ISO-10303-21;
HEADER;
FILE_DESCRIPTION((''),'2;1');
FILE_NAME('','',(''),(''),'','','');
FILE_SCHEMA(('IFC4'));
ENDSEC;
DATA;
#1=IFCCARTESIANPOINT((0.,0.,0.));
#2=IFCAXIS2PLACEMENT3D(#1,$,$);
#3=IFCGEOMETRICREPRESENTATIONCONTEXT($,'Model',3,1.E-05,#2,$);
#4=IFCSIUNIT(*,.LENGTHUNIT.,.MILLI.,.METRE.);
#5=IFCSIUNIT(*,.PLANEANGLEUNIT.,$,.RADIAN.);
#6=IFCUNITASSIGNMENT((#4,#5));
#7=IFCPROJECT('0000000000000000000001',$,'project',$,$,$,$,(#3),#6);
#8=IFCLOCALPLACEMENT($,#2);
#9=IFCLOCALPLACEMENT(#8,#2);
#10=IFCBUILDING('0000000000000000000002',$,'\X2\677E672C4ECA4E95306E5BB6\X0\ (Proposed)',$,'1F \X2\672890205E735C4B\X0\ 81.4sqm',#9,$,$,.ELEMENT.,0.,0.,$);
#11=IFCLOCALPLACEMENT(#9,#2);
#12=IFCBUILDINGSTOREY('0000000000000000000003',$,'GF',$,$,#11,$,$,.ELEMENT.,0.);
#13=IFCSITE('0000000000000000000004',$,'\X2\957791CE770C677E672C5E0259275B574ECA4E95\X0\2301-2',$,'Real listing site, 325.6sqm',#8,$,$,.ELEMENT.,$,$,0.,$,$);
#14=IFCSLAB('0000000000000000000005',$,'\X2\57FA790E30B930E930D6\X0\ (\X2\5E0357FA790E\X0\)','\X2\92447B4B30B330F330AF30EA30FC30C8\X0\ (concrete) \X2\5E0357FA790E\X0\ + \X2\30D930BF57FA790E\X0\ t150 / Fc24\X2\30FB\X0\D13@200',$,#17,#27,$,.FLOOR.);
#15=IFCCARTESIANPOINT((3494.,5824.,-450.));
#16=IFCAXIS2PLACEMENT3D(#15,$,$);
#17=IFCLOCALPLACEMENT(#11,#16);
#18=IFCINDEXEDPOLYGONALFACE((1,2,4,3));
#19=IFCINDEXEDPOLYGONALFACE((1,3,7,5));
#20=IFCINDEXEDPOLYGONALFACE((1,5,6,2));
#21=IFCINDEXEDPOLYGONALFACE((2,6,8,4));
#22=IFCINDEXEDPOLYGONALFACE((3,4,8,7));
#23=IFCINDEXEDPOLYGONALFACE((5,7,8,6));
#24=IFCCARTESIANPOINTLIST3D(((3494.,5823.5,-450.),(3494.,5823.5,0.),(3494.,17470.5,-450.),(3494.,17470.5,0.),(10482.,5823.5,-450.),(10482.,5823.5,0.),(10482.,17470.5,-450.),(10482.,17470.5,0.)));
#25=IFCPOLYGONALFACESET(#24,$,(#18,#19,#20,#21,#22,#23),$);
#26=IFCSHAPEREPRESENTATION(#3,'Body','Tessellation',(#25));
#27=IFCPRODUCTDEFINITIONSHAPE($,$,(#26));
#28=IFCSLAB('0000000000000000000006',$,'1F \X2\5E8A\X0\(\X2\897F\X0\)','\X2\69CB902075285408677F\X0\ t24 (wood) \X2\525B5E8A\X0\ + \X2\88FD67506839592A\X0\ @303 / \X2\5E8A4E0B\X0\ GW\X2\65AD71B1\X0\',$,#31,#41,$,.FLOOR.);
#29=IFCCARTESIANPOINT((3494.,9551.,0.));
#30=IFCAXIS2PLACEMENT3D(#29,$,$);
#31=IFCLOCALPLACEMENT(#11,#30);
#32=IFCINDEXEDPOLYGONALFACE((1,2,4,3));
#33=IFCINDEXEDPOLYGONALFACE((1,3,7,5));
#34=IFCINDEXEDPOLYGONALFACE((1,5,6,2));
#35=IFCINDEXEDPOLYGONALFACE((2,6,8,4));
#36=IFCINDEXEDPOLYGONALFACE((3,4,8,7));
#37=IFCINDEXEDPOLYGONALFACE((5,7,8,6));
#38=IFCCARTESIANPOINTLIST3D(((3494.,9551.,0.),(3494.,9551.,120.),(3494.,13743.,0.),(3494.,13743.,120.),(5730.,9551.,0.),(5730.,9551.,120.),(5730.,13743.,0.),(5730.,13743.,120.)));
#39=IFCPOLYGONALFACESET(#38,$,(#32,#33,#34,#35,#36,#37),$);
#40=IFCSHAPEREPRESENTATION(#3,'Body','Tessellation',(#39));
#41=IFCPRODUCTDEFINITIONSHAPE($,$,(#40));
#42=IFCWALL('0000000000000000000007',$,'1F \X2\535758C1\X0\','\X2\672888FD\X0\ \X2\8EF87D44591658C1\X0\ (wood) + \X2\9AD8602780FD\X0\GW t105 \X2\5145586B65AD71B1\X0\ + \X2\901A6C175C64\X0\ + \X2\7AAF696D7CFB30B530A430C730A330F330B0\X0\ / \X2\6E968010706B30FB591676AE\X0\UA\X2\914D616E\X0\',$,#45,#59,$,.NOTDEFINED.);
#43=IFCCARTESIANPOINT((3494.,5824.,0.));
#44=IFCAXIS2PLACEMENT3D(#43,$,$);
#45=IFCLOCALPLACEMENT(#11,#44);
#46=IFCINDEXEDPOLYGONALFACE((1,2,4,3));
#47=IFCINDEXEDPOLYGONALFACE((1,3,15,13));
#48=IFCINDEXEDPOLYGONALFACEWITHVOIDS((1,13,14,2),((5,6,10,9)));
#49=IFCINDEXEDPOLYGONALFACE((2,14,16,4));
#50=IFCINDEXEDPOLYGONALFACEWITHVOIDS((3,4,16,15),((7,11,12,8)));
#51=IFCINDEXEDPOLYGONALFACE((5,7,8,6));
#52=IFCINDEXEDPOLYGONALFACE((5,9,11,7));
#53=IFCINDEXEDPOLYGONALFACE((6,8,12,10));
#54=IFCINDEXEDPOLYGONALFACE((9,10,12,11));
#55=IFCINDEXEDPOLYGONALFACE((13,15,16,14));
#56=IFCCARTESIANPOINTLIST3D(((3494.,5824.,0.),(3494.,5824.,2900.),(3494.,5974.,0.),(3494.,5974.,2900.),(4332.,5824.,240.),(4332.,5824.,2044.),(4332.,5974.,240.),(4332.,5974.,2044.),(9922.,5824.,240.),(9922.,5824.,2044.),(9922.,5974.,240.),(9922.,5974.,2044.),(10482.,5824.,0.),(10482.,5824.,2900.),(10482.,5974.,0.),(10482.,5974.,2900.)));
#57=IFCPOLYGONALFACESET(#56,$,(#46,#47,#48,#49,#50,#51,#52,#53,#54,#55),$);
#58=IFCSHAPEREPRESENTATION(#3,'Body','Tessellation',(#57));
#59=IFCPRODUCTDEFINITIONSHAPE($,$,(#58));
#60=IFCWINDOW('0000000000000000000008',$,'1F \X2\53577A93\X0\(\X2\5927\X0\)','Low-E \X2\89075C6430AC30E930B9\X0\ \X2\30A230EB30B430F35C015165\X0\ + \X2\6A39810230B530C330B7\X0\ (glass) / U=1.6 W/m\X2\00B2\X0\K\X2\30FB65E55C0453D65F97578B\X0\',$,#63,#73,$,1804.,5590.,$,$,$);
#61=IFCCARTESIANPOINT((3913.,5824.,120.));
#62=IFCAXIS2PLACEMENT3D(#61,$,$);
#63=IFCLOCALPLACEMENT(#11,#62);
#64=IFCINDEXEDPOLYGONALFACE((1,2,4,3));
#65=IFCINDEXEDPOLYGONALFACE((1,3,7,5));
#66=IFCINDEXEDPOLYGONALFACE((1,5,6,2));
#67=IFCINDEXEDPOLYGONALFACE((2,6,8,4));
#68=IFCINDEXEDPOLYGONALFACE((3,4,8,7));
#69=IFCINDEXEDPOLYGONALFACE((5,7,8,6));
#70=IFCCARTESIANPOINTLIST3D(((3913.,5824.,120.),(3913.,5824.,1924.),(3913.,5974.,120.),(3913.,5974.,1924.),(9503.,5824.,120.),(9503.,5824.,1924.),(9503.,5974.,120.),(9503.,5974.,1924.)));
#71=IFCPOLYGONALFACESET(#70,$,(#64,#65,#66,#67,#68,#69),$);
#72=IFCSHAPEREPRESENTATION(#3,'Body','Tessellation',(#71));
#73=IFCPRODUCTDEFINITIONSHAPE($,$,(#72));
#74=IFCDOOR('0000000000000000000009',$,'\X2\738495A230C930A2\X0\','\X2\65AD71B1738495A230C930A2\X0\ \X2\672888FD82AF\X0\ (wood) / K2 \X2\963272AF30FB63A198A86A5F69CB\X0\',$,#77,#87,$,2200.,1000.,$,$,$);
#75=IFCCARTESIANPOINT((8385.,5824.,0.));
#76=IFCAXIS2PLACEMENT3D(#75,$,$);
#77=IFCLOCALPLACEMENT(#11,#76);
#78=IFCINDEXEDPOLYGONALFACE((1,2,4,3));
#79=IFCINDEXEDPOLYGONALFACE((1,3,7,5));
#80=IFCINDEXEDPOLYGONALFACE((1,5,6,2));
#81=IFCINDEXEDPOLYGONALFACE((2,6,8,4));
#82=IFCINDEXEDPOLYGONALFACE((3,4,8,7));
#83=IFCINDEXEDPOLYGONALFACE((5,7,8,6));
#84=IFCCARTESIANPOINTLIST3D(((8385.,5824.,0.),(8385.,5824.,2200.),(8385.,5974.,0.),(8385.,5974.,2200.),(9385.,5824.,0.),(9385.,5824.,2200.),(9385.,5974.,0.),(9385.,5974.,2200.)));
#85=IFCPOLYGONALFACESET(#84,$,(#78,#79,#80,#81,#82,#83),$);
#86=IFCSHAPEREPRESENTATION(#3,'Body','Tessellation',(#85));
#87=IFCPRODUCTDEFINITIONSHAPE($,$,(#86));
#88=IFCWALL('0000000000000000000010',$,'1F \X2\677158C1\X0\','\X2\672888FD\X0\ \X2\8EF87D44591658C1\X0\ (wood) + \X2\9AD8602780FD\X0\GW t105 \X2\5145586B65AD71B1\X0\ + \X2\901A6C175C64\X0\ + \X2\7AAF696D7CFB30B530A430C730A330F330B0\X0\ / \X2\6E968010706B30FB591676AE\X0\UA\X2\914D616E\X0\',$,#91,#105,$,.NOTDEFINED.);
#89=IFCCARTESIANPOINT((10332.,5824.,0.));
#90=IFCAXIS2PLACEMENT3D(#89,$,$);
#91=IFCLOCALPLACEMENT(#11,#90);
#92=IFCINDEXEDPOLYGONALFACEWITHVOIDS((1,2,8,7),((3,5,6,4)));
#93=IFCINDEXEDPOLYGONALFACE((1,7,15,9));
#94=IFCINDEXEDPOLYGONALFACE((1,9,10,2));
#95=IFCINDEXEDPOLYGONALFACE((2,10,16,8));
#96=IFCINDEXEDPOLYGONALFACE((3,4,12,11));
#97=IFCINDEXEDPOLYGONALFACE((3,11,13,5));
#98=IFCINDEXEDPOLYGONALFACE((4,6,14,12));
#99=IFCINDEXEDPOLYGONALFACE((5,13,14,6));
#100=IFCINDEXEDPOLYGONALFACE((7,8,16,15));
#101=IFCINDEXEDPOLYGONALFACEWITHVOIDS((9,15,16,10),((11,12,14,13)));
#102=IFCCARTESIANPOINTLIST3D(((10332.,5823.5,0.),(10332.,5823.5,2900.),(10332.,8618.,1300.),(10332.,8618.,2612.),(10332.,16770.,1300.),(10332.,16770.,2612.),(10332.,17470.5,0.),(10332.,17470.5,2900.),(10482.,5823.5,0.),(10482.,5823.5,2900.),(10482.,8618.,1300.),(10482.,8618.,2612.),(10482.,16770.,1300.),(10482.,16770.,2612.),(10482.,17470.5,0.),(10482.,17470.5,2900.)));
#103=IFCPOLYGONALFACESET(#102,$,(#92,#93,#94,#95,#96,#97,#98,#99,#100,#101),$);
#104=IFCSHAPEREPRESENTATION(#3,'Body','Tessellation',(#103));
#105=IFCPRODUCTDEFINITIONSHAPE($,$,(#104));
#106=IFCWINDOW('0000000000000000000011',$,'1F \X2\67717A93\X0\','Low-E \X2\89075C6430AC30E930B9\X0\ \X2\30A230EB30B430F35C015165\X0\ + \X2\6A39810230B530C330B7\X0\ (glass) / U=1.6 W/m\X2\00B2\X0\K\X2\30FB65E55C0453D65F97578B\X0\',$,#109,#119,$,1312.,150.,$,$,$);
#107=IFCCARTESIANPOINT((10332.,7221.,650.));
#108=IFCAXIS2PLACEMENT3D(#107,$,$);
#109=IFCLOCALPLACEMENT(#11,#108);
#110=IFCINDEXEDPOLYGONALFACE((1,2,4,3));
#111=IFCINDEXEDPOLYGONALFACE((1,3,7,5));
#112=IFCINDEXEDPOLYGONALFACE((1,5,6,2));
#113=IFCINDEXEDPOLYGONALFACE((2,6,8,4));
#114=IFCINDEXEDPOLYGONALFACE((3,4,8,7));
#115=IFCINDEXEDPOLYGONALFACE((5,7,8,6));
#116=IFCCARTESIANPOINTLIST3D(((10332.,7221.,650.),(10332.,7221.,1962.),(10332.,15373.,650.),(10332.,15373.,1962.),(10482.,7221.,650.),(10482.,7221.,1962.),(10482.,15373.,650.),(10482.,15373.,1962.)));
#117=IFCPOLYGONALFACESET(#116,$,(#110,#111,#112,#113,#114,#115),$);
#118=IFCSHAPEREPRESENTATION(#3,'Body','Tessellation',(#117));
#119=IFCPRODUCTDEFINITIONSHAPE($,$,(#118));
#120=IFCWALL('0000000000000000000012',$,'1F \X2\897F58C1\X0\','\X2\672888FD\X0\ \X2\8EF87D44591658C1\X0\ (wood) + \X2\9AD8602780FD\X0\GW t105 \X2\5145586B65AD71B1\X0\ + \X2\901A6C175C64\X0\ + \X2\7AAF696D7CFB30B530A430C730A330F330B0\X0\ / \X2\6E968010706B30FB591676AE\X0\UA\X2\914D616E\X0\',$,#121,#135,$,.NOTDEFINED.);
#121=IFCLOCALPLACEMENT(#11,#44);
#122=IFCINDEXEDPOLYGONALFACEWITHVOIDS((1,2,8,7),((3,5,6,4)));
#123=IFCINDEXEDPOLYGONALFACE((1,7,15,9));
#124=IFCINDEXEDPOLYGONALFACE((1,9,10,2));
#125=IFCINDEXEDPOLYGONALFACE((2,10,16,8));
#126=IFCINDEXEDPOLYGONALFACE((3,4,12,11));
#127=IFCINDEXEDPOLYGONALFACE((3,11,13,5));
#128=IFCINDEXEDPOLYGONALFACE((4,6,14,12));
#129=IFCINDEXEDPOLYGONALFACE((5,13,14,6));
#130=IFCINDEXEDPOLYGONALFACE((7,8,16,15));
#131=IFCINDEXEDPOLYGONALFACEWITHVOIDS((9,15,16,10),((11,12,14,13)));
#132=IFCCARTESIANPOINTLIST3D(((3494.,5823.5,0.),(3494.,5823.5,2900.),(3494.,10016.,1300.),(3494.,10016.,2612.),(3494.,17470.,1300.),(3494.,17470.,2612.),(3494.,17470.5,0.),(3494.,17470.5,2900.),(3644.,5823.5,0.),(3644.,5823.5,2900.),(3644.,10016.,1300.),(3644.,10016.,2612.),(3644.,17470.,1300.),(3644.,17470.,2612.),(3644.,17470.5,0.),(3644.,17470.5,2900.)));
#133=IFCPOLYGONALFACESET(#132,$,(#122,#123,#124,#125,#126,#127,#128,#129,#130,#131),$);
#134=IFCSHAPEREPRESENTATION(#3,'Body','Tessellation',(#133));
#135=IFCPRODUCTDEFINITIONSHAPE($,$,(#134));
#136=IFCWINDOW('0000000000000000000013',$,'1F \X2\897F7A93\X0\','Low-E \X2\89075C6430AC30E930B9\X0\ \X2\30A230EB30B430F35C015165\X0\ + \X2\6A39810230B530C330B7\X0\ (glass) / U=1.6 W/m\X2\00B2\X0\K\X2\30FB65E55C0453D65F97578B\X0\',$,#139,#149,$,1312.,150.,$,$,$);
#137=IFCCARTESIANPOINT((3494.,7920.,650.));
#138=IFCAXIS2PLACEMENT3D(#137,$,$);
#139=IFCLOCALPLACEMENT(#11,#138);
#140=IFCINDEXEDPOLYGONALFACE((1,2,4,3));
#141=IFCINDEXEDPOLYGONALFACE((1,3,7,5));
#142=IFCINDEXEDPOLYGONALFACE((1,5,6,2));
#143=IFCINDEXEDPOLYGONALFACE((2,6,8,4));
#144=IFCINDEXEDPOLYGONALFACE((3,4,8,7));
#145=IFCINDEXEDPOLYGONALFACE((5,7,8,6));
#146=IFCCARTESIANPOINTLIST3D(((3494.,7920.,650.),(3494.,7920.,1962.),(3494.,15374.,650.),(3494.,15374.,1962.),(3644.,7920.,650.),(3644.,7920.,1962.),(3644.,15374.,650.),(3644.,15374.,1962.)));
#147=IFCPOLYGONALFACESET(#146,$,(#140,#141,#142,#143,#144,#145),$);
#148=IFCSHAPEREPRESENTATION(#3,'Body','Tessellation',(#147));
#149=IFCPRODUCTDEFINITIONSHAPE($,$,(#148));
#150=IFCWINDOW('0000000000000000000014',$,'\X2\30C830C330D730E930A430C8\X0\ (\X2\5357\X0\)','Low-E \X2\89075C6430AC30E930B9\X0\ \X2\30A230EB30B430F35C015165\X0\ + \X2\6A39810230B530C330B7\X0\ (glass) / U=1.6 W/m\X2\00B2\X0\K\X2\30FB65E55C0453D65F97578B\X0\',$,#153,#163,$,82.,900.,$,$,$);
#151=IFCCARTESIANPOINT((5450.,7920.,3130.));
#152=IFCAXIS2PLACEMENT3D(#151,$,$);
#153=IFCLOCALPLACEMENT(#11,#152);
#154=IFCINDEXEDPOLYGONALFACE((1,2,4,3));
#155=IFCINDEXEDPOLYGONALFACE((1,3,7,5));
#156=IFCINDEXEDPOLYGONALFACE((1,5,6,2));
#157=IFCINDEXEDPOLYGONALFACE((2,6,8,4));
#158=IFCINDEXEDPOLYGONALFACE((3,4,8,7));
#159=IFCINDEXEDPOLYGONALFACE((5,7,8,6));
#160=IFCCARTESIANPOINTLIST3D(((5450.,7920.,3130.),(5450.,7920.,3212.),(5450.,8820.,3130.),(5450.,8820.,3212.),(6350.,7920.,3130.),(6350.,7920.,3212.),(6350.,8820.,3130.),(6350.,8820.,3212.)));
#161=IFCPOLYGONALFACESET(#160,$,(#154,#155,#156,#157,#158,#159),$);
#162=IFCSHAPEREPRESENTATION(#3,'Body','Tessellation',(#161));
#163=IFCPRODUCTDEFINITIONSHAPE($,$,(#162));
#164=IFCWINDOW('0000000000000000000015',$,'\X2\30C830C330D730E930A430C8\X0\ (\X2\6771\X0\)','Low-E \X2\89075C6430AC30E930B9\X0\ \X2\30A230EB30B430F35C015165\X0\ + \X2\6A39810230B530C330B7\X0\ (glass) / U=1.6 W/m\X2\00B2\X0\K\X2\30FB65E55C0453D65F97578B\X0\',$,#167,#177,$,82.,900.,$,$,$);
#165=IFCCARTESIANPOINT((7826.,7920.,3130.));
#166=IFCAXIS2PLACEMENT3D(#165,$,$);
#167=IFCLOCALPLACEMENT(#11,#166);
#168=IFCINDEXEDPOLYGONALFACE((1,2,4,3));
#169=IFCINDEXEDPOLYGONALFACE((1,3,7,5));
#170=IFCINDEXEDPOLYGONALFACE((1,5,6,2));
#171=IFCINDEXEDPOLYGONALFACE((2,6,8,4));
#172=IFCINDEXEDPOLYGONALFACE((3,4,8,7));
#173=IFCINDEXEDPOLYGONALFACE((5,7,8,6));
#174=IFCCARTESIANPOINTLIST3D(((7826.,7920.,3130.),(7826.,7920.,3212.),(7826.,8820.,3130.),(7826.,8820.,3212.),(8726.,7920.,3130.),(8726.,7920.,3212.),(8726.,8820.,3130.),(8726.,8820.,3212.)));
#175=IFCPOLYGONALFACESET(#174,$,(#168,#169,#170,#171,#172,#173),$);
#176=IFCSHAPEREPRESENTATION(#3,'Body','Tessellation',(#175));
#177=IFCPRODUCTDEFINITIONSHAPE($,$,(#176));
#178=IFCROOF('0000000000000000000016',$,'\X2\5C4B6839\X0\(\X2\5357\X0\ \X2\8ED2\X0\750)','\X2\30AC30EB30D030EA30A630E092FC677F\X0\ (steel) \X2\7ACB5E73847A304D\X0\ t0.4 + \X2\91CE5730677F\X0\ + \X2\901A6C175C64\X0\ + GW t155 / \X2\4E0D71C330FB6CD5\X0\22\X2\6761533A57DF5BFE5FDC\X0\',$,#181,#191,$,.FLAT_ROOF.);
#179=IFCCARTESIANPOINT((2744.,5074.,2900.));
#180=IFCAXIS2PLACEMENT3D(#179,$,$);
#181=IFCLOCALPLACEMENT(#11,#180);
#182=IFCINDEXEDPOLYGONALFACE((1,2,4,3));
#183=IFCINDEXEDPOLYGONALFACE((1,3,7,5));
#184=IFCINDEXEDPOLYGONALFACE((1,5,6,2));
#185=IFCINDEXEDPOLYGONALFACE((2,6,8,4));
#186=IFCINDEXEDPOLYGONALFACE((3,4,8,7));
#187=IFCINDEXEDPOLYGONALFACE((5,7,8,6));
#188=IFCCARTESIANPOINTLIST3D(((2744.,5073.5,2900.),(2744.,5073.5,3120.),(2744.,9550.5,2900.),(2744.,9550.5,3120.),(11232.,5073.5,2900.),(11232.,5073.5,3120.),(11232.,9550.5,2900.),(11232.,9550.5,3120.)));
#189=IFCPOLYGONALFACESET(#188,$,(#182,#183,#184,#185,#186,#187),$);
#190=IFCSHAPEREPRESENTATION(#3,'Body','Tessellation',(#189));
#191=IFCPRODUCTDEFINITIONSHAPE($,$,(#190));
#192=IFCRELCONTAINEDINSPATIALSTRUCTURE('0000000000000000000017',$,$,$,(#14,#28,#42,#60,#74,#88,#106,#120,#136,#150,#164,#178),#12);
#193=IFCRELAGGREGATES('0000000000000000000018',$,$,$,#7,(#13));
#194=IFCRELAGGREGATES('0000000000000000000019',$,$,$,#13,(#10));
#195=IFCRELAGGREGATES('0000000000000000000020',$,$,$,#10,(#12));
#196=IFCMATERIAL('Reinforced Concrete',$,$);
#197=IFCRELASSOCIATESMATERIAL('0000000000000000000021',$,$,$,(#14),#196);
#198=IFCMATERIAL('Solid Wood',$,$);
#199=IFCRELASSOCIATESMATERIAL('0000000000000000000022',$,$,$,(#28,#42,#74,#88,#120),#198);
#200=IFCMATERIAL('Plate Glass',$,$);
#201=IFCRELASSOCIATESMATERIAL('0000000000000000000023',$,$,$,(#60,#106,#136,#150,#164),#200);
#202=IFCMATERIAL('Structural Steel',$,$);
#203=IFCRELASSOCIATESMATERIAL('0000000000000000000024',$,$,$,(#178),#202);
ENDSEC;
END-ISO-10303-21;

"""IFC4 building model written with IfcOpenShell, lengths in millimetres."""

from ifc_helpers import new_model, si_unit, frame, frame_2d, origin, place, context, project, spatial, rectangle, extrude, material, element, fill, save


model = new_model("IFC4")

# Units and contexts
model_context = context("Model", 3, precision=1e-05, world=origin())
ifc_project = project(units=[si_unit("LENGTHUNIT", "METRE", prefix="MILLI"), si_unit("PLANEANGLEUNIT", "RADIAN")], contexts=[model_context])

# Site, building, storey
site_placement = place(None, origin())
site = spatial("IfcSite", under=ifc_project, at=site_placement, Name="長野県松本市大字今井2301-2", ObjectType="Real listing site, 325.6sqm", CompositionType="ELEMENT", RefElevation=0.0)
building_placement = place(site_placement, origin())
building = spatial("IfcBuilding", under=site, at=building_placement, Name="松本今井の家 (Proposed)", ObjectType="1F 木造平屋 81.4sqm", CompositionType="ELEMENT", ElevationOfRefHeight=0.0, ElevationOfTerrain=0.0)
storey_placement = place(building_placement, origin())
storey = spatial("IfcBuildingStorey", under=building, at=storey_placement, Name="GF", CompositionType="ELEMENT", Elevation=0.0)

# Slabs
ifc_material_1 = material(Name="Reinforced Concrete")
slab_1_placement = place(storey_placement, frame((3494.0, 5824.0, -450.0)))
element("IfcSlab", 1, at=slab_1_placement, inside=storey, material=ifc_material_1, Name="基礎スラブ (布基礎)", Description="鉄筋コンクリート (concrete) 布基礎 + ベタ基礎 t150 / Fc24・D13@200", PredefinedType="FLOOR", context=model_context, shape_type="SweptSolid", body=[
    extrude(rectangle(XDim=6988.0, YDim=11647.0, at=frame_2d((3494.0, 5823.0))), frame((3494.0, 5824.0, -450.0)), (0.0, 0.0, 1.0), 450.0),
])
ifc_material_2 = material(Name="Solid Wood")
slab_2_placement = place(storey_placement, frame((3494.0, 9551.0, 0.0)))
element("IfcSlab", 2, at=slab_2_placement, inside=storey, material=ifc_material_2, Name="1F 床(西)", Description="構造用合板 t24 (wood) 剛床 + 製材根太 @303 / 床下 GW断熱", PredefinedType="FLOOR", context=model_context, shape_type="SweptSolid", body=[
    extrude(rectangle(XDim=2236.0, YDim=4192.0, at=frame_2d((1118.0, 2096.0))), frame((3494.0, 9551.0, 0.0)), (0.0, 0.0, 1.0), 120.0),
])

# Wall, openings, window, door
wall_1_placement = place(storey_placement, frame((3494.0, 5824.0, 0.0)))
wall_1 = element("IfcWall", 3, at=wall_1_placement, inside=storey, material=ifc_material_2, Name="1F 南壁", Description="木製 軸組外壁 (wood) + 高性能GW t105 充填断熱 + 通気層 + 窯業系サイディング / 準耐火・外皮UA配慮", PredefinedType="NOTDEFINED", context=model_context, shape_type="SweptSolid", body=[
    extrude(rectangle(XDim=6988.0, YDim=150.0, at=frame_2d((3494.0, 75.0))), frame((3494.0, 5824.0, 0.0)), (0.0, 0.0, 1.0), 2900.0),
])
opening_1_placement = place(storey_placement, frame((3913.0, 5824.0, 120.0)))
opening_1 = element("IfcOpeningElement", 4, at=opening_1_placement, cuts=wall_1, PredefinedType="NOTDEFINED", context=model_context, shape_type="SweptSolid", body=[
    extrude(rectangle(XDim=5590.0, YDim=150.0, at=frame_2d((2795.0, 75.0))), frame((3913.0, 5824.0, 120.0)), (0.0, 0.0, 1.0), 1804.0),
])
opening_2_placement = place(storey_placement, frame((8385.0, 5824.0, 0.0)))
opening_2 = element("IfcOpeningElement", 5, at=opening_2_placement, cuts=wall_1, PredefinedType="NOTDEFINED", context=model_context, shape_type="SweptSolid", body=[
    extrude(rectangle(XDim=1000.0, YDim=150.0, at=frame_2d((500.0, 75.0))), frame((8385.0, 5824.0, 0.0)), (0.0, 0.0, 1.0), 2200.0),
])
ifc_material_3 = material(Name="Plate Glass")
window_1_placement = place(storey_placement, frame((3913.0, 5824.0, 120.0)))
window_1 = element("IfcWindow", 6, at=window_1_placement, inside=storey, material=ifc_material_3, Name="1F 南窓(大)", Description="Low-E 複層ガラス アルゴン封入 + 樹脂サッシ (glass) / U=1.6 W/m²K・日射取得型", OverallHeight=1804.0, OverallWidth=5590.0, context=model_context, shape_type="SweptSolid", body=[
    extrude(rectangle(XDim=5590.0, YDim=150.0, at=frame_2d((2795.0, 75.0))), frame((3913.0, 5824.0, 120.0)), (0.0, 0.0, 1.0), 1804.0),
])
fill(opening_1, window_1)
door_placement = place(storey_placement, frame((8385.0, 5824.0, 0.0)))
door = element("IfcDoor", 7, at=door_placement, inside=storey, material=ifc_material_2, Name="玄関ドア", Description="断熱玄関ドア 木製芯 (wood) / K2 防犯・採風機構", OverallHeight=2200.0, OverallWidth=1000.0, context=model_context, shape_type="SweptSolid", body=[
    extrude(rectangle(XDim=1000.0, YDim=150.0, at=frame_2d((500.0, 75.0))), frame((8385.0, 5824.0, 0.0)), (0.0, 0.0, 1.0), 2200.0),
])
fill(opening_2, door)

# Walls, openings, windows
wall_2_placement = place(storey_placement, frame((10332.0, 5824.0, 0.0)))
wall_2 = element("IfcWall", 8, at=wall_2_placement, inside=storey, material=ifc_material_2, Name="1F 東壁", Description="木製 軸組外壁 (wood) + 高性能GW t105 充填断熱 + 通気層 + 窯業系サイディング / 準耐火・外皮UA配慮", PredefinedType="NOTDEFINED", context=model_context, shape_type="SweptSolid", body=[
    extrude(rectangle(XDim=150.0, YDim=11647.0, at=frame_2d((75.0, 5823.0))), frame((10332.0, 5824.0, 0.0)), (0.0, 0.0, 1.0), 2900.0),
])
opening_3_placement = place(storey_placement, frame((10332.0, 7221.0, 650.0)))
opening_3 = element("IfcOpeningElement", 9, at=opening_3_placement, cuts=wall_2, PredefinedType="NOTDEFINED", context=model_context, shape_type="SweptSolid", body=[
    extrude(rectangle(XDim=150.0, YDim=8152.0, at=frame_2d((75.0, 4076.0))), frame((10332.0, 7221.0, 650.0)), (0.0, 0.0, 1.0), 1312.0),
])
window_2_placement = place(storey_placement, frame((10332.0, 7221.0, 650.0)))
window_2 = element("IfcWindow", 10, at=window_2_placement, inside=storey, material=ifc_material_3, Name="1F 東窓", Description="Low-E 複層ガラス アルゴン封入 + 樹脂サッシ (glass) / U=1.6 W/m²K・日射取得型", OverallHeight=1312.0, OverallWidth=150.0, context=model_context, shape_type="SweptSolid", body=[
    extrude(rectangle(XDim=150.0, YDim=8152.0, at=frame_2d((75.0, 4076.0))), frame((10332.0, 7221.0, 650.0)), (0.0, 0.0, 1.0), 1312.0),
])
fill(opening_3, window_2)
wall_3_placement = place(storey_placement, frame((3494.0, 5824.0, 0.0)))
wall_3 = element("IfcWall", 11, at=wall_3_placement, inside=storey, material=ifc_material_2, Name="1F 西壁", Description="木製 軸組外壁 (wood) + 高性能GW t105 充填断熱 + 通気層 + 窯業系サイディング / 準耐火・外皮UA配慮", PredefinedType="NOTDEFINED", context=model_context, shape_type="SweptSolid", body=[
    extrude(rectangle(XDim=150.0, YDim=11647.0, at=frame_2d((75.0, 5823.0))), frame((3494.0, 5824.0, 0.0)), (0.0, 0.0, 1.0), 2900.0),
])
opening_4_placement = place(storey_placement, frame((3494.0, 7920.0, 650.0)))
opening_4 = element("IfcOpeningElement", 12, at=opening_4_placement, cuts=wall_3, PredefinedType="NOTDEFINED", context=model_context, shape_type="SweptSolid", body=[
    extrude(rectangle(XDim=150.0, YDim=7454.0, at=frame_2d((75.0, 3727.0))), frame((3494.0, 7920.0, 650.0)), (0.0, 0.0, 1.0), 1312.0),
])
window_3_placement = place(storey_placement, frame((3494.0, 7920.0, 650.0)))
window_3 = element("IfcWindow", 13, at=window_3_placement, inside=storey, material=ifc_material_3, Name="1F 西窓", Description="Low-E 複層ガラス アルゴン封入 + 樹脂サッシ (glass) / U=1.6 W/m²K・日射取得型", OverallHeight=1312.0, OverallWidth=150.0, context=model_context, shape_type="SweptSolid", body=[
    extrude(rectangle(XDim=150.0, YDim=7454.0, at=frame_2d((75.0, 3727.0))), frame((3494.0, 7920.0, 650.0)), (0.0, 0.0, 1.0), 1312.0),
])
fill(opening_4, window_3)

# Windows
window_4_placement = place(storey_placement, frame((5450.0, 7920.0, 3130.0)))
element("IfcWindow", 14, at=window_4_placement, inside=storey, material=ifc_material_3, Name="トップライト (南)", Description="Low-E 複層ガラス アルゴン封入 + 樹脂サッシ (glass) / U=1.6 W/m²K・日射取得型", OverallHeight=82.0, OverallWidth=900.0, context=model_context, shape_type="SweptSolid", body=[
    extrude(rectangle(XDim=900.0, YDim=900.0, at=frame_2d((450.0, 450.0))), frame((5450.0, 7920.0, 3130.0)), (0.0, 0.0, 1.0), 82.0),
])
window_5_placement = place(storey_placement, frame((7826.0, 7920.0, 3130.0)))
element("IfcWindow", 15, at=window_5_placement, inside=storey, material=ifc_material_3, Name="トップライト (東)", Description="Low-E 複層ガラス アルゴン封入 + 樹脂サッシ (glass) / U=1.6 W/m²K・日射取得型", OverallHeight=82.0, OverallWidth=900.0, context=model_context, shape_type="SweptSolid", body=[
    extrude(rectangle(XDim=900.0, YDim=900.0, at=frame_2d((450.0, 450.0))), frame((7826.0, 7920.0, 3130.0)), (0.0, 0.0, 1.0), 82.0),
])

# Roof
ifc_material_4 = material(Name="Structural Steel")
roof_placement = place(storey_placement, frame((2744.0, 5074.0, 2900.0)))
element("IfcRoof", 16, at=roof_placement, inside=storey, material=ifc_material_4, Name="屋根(南 軒750)", Description="ガルバリウム鋼板 (steel) 立平葺き t0.4 + 野地板 + 通気層 + GW t155 / 不燃・法22条区域対応", PredefinedType="FLAT_ROOF", context=model_context, shape_type="SweptSolid", body=[
    extrude(rectangle(XDim=8488.0, YDim=4477.0, at=frame_2d((4244.0, 2238.0))), frame((2744.0, 5074.0, 2900.0)), (0.0, 0.0, 1.0), 220.0),
])

save(model, "model.ifc")
